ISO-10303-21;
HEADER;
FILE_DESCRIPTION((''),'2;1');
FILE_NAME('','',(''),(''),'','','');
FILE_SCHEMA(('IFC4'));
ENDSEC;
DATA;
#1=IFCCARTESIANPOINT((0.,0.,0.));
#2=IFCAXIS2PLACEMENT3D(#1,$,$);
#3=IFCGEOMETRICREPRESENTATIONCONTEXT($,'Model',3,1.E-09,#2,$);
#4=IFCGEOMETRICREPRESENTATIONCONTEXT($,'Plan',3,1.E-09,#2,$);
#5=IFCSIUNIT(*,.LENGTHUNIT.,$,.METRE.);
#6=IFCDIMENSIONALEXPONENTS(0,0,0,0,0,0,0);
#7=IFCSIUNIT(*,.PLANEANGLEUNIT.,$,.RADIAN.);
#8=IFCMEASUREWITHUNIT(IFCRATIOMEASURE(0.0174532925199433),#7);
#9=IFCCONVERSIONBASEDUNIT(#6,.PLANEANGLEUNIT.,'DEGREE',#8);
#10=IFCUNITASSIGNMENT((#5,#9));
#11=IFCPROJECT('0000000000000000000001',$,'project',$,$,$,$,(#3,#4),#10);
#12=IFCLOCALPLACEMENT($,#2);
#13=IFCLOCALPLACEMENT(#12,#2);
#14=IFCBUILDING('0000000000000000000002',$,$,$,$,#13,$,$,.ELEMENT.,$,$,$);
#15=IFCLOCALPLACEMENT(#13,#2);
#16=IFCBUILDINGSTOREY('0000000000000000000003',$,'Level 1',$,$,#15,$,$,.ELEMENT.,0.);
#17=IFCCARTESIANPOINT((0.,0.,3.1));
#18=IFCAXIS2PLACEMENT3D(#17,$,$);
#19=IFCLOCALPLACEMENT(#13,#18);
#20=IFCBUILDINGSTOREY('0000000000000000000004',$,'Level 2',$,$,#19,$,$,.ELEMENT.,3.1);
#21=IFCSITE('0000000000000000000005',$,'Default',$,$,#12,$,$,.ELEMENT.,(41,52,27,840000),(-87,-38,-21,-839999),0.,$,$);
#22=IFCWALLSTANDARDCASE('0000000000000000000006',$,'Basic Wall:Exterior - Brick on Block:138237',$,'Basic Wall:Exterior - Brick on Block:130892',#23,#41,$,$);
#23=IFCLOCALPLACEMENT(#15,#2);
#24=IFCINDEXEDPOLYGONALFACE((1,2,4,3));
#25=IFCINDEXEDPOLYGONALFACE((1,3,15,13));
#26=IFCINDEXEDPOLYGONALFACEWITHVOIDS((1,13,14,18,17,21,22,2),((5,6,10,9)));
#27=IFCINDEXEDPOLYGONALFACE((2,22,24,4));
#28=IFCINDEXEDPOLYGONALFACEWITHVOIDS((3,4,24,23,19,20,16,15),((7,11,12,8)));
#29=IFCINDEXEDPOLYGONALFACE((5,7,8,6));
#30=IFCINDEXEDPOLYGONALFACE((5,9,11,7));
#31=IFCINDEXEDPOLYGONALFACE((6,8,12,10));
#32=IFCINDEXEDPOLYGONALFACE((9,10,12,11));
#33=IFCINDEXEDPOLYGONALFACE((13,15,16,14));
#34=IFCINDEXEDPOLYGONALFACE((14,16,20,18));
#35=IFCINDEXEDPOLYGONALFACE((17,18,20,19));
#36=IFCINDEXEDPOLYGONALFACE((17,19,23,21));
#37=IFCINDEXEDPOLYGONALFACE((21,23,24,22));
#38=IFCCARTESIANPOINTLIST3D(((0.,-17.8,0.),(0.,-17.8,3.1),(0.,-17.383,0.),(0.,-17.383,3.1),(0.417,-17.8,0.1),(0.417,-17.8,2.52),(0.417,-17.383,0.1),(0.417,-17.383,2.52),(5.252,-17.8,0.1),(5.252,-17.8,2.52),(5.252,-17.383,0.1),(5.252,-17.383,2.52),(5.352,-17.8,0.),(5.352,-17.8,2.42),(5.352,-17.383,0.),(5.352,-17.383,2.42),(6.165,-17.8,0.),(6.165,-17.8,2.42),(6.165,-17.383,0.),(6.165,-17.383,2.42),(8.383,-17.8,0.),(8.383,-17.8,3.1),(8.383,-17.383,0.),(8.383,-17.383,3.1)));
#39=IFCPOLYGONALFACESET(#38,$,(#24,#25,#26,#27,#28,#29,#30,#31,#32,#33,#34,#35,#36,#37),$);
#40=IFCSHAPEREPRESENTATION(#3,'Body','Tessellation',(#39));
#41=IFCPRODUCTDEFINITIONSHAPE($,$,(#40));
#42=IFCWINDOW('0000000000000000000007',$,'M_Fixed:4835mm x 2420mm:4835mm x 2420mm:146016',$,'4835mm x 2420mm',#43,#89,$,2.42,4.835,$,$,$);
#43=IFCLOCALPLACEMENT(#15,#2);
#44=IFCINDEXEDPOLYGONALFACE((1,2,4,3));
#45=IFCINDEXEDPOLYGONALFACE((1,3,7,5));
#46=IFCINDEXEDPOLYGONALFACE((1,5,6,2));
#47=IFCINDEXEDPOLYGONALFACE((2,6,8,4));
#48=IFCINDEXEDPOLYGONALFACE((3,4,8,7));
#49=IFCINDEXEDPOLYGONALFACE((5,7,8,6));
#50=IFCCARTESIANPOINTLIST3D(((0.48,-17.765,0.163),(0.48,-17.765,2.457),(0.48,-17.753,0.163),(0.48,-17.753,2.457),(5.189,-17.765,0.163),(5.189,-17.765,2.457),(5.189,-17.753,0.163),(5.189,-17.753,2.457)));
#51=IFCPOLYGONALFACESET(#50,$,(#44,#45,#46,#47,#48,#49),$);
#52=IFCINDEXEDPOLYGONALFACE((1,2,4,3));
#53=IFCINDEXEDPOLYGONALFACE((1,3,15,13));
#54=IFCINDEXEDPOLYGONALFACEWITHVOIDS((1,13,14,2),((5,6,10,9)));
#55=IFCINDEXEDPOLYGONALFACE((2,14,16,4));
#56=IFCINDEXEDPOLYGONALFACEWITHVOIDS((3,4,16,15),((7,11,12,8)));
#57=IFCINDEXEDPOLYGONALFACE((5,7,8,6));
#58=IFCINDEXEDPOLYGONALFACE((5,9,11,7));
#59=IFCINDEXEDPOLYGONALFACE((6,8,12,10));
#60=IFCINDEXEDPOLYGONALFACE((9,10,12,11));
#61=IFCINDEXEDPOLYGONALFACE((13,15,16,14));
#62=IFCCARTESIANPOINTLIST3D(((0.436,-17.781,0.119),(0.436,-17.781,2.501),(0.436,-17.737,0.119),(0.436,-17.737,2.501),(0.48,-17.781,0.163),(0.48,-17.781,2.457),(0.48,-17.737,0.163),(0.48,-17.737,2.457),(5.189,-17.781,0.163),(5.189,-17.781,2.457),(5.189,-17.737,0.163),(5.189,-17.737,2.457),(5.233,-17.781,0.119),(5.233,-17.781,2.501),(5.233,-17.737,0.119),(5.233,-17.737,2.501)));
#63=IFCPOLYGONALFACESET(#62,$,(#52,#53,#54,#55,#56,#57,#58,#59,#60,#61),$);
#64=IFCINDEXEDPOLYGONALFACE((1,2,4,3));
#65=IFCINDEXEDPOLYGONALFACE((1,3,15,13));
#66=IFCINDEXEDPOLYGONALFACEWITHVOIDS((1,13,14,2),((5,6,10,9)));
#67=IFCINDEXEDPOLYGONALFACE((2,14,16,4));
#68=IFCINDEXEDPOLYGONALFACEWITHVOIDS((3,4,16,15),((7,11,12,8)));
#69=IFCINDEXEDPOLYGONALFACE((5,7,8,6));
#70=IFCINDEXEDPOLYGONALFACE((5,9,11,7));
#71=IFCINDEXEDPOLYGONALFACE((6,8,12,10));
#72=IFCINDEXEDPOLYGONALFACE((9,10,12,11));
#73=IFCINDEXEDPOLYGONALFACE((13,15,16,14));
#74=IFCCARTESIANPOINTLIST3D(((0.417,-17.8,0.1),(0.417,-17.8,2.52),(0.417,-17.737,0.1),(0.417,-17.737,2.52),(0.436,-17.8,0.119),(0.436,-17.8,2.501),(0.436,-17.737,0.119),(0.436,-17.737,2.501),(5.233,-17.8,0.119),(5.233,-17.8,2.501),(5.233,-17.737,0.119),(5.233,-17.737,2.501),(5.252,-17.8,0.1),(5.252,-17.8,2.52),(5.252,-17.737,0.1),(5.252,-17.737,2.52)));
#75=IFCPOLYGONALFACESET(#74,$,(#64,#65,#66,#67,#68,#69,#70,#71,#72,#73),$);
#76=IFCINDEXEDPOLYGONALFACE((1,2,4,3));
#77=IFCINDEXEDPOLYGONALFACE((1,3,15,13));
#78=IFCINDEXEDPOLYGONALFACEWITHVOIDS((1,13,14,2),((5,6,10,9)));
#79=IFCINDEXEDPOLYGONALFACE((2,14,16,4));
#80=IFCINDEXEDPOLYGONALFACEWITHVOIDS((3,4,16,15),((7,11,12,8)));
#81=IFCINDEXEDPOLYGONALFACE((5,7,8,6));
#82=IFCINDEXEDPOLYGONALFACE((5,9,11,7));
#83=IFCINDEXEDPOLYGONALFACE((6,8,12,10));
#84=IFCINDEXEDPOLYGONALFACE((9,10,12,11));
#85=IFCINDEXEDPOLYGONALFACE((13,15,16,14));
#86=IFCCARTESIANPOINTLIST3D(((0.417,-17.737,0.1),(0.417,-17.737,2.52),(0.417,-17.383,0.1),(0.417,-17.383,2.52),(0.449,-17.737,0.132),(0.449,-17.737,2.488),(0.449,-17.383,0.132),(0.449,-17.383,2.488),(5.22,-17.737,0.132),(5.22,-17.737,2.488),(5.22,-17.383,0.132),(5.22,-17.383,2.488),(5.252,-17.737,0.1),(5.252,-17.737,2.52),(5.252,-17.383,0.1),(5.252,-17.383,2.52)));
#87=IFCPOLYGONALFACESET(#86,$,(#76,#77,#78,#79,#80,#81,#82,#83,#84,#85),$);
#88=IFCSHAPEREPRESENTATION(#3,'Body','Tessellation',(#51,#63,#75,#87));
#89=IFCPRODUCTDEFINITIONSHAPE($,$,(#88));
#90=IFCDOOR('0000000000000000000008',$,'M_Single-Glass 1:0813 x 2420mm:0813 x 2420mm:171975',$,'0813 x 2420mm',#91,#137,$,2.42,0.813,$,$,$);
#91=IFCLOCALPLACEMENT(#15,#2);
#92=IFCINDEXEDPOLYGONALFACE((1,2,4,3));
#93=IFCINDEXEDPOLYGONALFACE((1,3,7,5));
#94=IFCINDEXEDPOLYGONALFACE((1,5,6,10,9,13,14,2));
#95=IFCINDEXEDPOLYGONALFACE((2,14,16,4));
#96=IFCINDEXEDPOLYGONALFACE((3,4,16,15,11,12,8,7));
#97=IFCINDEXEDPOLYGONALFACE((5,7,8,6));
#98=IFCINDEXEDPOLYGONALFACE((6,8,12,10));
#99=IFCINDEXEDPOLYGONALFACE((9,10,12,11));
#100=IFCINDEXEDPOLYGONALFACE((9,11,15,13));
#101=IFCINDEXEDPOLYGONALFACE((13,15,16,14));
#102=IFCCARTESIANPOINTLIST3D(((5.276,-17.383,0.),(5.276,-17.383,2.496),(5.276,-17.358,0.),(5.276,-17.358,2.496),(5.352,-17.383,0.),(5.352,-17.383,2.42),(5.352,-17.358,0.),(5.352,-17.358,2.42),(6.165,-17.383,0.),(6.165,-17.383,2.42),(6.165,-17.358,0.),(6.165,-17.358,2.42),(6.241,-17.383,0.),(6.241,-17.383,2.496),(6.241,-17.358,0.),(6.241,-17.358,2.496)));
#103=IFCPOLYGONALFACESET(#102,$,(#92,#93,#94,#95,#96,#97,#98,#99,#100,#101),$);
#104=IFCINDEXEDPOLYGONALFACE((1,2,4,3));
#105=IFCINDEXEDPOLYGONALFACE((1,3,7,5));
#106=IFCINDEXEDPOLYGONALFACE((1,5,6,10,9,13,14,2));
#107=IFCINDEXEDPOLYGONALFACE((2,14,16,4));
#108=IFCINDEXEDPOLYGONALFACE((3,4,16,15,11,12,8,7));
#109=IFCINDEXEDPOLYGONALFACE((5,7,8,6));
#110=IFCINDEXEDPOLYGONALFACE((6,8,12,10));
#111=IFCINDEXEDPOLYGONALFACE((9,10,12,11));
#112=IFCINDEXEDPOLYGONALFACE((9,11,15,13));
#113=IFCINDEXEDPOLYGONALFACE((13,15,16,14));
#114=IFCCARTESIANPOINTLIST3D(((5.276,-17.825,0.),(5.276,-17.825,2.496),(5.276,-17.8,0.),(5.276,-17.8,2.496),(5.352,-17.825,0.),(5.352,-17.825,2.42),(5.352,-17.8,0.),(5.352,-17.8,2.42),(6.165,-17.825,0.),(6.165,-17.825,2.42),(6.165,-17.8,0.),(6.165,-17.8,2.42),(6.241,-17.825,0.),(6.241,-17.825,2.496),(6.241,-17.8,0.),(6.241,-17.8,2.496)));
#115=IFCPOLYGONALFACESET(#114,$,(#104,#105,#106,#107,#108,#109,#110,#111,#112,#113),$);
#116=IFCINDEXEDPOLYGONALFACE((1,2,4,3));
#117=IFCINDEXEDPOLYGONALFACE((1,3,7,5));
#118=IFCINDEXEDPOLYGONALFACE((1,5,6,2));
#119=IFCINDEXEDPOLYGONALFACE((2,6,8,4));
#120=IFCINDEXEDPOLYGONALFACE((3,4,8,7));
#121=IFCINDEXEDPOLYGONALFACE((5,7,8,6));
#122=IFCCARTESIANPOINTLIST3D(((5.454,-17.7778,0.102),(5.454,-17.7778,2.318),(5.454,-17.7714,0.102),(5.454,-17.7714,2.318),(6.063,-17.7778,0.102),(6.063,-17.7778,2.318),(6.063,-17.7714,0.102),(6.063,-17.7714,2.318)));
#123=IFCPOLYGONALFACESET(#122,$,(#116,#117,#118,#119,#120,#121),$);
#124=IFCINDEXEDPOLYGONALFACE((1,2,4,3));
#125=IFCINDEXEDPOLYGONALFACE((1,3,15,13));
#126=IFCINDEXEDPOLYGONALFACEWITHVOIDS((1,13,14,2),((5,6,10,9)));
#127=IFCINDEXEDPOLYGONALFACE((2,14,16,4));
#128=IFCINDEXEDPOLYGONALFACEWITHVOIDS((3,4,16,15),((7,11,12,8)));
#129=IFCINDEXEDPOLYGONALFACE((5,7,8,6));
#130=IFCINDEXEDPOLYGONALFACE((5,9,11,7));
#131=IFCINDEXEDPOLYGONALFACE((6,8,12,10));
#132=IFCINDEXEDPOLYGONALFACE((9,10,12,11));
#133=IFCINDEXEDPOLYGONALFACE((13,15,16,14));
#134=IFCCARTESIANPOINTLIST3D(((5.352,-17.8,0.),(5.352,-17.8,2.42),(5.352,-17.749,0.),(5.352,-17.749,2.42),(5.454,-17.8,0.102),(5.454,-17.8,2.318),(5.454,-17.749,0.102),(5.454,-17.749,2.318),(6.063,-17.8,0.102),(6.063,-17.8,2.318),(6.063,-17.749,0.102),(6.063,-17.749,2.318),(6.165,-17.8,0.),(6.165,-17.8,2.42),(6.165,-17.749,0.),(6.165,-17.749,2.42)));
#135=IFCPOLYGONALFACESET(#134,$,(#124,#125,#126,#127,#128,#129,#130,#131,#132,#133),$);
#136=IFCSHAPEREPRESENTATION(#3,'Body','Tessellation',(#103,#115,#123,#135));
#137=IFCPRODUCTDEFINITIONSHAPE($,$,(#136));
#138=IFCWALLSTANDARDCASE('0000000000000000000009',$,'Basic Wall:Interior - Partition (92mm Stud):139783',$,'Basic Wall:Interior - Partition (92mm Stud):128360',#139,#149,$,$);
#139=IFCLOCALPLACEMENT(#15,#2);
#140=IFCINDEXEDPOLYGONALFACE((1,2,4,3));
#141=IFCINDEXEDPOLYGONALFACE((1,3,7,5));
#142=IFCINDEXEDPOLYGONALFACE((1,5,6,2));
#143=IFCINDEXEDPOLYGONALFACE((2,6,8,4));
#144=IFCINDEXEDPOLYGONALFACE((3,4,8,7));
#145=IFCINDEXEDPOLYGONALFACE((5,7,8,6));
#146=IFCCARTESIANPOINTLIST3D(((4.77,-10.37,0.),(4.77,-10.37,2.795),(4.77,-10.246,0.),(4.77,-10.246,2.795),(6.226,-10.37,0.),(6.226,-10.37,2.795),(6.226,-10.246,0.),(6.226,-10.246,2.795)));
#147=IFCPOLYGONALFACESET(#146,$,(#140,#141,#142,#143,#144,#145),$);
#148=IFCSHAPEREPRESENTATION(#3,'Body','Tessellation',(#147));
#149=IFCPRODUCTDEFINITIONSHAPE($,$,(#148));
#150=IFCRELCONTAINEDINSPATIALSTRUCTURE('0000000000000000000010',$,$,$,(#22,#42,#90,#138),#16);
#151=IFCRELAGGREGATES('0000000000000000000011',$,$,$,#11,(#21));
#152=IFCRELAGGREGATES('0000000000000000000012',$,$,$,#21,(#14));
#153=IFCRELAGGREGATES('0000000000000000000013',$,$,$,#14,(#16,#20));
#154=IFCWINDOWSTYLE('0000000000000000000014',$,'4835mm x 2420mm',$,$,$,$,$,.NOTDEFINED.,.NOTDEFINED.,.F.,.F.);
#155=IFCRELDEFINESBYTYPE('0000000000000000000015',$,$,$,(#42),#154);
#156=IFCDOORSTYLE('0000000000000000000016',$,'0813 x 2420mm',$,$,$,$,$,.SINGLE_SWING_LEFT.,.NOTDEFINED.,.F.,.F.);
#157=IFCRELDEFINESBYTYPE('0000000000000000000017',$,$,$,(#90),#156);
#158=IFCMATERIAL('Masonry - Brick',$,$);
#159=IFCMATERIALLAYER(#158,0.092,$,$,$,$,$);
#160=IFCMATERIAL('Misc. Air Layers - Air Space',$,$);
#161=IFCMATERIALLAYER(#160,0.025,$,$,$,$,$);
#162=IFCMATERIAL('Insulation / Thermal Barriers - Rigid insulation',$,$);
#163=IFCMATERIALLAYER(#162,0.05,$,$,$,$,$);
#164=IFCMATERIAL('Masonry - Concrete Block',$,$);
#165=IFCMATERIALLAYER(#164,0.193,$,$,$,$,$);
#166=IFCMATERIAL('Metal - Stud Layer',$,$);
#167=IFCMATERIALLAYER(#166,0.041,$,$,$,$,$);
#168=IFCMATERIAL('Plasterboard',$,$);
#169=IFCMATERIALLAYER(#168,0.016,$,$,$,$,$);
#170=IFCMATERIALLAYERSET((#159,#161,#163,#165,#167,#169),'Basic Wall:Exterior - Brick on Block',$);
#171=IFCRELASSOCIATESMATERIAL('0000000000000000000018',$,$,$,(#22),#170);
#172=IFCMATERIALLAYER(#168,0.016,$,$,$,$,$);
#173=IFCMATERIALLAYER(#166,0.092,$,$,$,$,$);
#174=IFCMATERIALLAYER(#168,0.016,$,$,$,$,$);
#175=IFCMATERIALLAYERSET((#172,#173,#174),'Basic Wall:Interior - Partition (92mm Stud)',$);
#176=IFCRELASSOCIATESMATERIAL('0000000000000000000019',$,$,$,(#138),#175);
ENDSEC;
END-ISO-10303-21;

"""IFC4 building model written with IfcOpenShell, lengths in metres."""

from ifc_helpers import new_model, entity, si_unit, converted_unit, frame, frame_2d, origin, origin_2d_with_axis, place, context, project, spatial, polyline, rectangle, outline, extrude, source, transform, mapped, material, layer, layer_set, layer_usage, type_object, type_shapes, element, fill, save


model = new_model("IFC4")

# Units and contexts
model_context = context("Model", 3, precision=1e-09, world=origin())
plan_context = context("Plan", 3, precision=1e-09, world=origin())
ifc_project = project(units=[si_unit("LENGTHUNIT", "METRE"), converted_unit("PLANEANGLEUNIT", "DEGREE", entity("IfcRatioMeasure", 0.0174532925199433), si_unit("PLANEANGLEUNIT", "RADIAN"), dimensions=[0, 0, 0, 0, 0, 0, 0])], contexts=[model_context, plan_context])

# Site, building, storey
site_placement = place(None, origin())
site = spatial("IfcSite", under=ifc_project, at=site_placement, Name="Default", CompositionType="ELEMENT", RefLatitude=(41, 52, 27, 840000), RefLongitude=(-87, -38, -21, -839999), RefElevation=0.0)
building_placement = place(site_placement, origin())
building = spatial("IfcBuilding", under=site, at=building_placement, CompositionType="ELEMENT")
storey_1_placement = place(building_placement, origin())
storey_1 = spatial("IfcBuildingStorey", under=building, at=storey_1_placement, Name="Level 1", CompositionType="ELEMENT", Elevation=0.0)

# Shared definitions
ifc_material_1 = material(Name="Metal - Stud Layer")
ifc_material_2 = material(Name="Plasterboard")
ifc_material_3 = material(Name="Masonry - Concrete Block")
ifc_material_4 = material(Name="Misc. Air Layers - Air Space")

# Wall, openings, window, door
ifc_material_5 = material(Name="Masonry - Brick")
ifc_layer_1 = layer(ifc_material_5, 0.092)
ifc_layer_2 = layer(ifc_material_4, 0.025)
ifc_material_6 = material(Name="Insulation / Thermal Barriers - Rigid insulation")
ifc_layer_3 = layer(ifc_material_6, 0.05)
ifc_layer_4 = layer(ifc_material_3, 0.193)
ifc_layer_5 = layer(ifc_material_1, 0.041)
ifc_layer_6 = layer(ifc_material_2, 0.016)
ifc_layer_set_1 = layer_set([ifc_layer_1, ifc_layer_2, ifc_layer_3, ifc_layer_4, ifc_layer_5, ifc_layer_6], Name="Basic Wall:Exterior - Brick on Block")
ifc_layer_usage_1 = layer_usage(ifc_layer_set_1, "AXIS2", "NEGATIVE", 0.2085)
wall_1_placement = place(storey_1_placement, frame((8.383, -17.5915, 0.0), z_axis=(0.0, 0.0, 1.0), x_axis=(-1.0, 0.0, 0.0)))
wall_1 = element("IfcWallStandardCase", 1, at=wall_1_placement, inside=storey_1, material=ifc_layer_usage_1, Name="Basic Wall:Exterior - Brick on Block:138237", ObjectType="Basic Wall:Exterior - Brick on Block:130892", context=model_context, shape_type="SweptSolid", body=[
    extrude(rectangle(XDim=8.383, YDim=0.417, at=frame_2d((4.1915, 0.0), x_axis=(-1.0, 0.0))), origin(), (0.0, 0.0, 1.0), 3.1),
])
opening_1_placement = place(wall_1_placement, frame((2.218, -0.2085, 0.0)))
opening_1 = element("IfcOpeningElement", 2, at=opening_1_placement, cuts=wall_1, ObjectType="Opening", context=model_context, shape_type="SweptSolid", body=[
    extrude(rectangle(XDim=0.813, YDim=2.42, at=frame_2d((1.21, 0.4065), x_axis=(0.0, -1.0))), frame((0.0, 0.0, 0.0), z_axis=(0.0, 1.0, 0.0), x_axis=(0.0, 0.0, 1.0)), (0.0, 0.0, 1.0), 0.417),
])
opening_2_placement = place(wall_1_placement, frame((3.131, -0.2085, 0.1)))
opening_2 = element("IfcOpeningElement", 3, at=opening_2_placement, cuts=wall_1, ObjectType="Opening", context=model_context, shape_type="SweptSolid", body=[
    extrude(rectangle(XDim=2.42, YDim=4.835, at=frame_2d((1.21, 2.4175), x_axis=(1.0, 0.0))), frame((0.0, 0.0, 0.0), z_axis=(0.0, 1.0, 0.0), x_axis=(0.0, 0.0, 1.0)), (0.0, 0.0, 1.0), 0.417),
])
window_style_1 = type_object("IfcWindowStyle", Name="4835mm x 2420mm", ConstructionType="NOTDEFINED", OperationType="NOTDEFINED", ParameterTakesPrecedence=False, Sizeable=False)
shared_shape_1 = source(origin(), model_context, "Body", "SweptSolid", [
    extrude(rectangle(XDim=0.012, YDim=4.709, at=origin_2d_with_axis()), frame((2.4175, 0.376, 0.063), z_axis=(0.0, 0.0, 1.0), x_axis=(0.0, -1.0, 0.0)), (0.0, 0.0, 1.0), 2.294),
    extrude(outline(polyline([(-2.3985, -1.191), (2.3985, -1.191), (2.3985, 1.191), (-2.3985, 1.191), (-2.3985, -1.191)]), holes=[polyline([(-2.3545, -1.147), (-2.3545, 1.147), (2.3545, 1.147), (2.3545, -1.147), (-2.3545, -1.147)])]), frame((2.4175, 0.354, 1.21), z_axis=(0.0, 1.0, 0.0), x_axis=(1.0, 0.0, 0.0)), (0.0, 0.0, 1.0), 0.044),
    extrude(outline(polyline([(-2.4175, -1.21), (2.4175, -1.21), (2.4175, 1.21), (-2.4175, 1.21), (-2.4175, -1.21)]), holes=[polyline([(-2.3985, -1.191), (-2.3985, 1.191), (2.3985, 1.191), (2.3985, -1.191), (-2.3985, -1.191)])]), frame((2.4175, 0.354, 1.21), z_axis=(0.0, 1.0, 0.0), x_axis=(1.0, 0.0, 0.0)), (0.0, 0.0, 1.0), 0.063),
    extrude(outline(polyline([(-2.4175, -1.21), (2.4175, -1.21), (2.4175, 1.21), (-2.4175, 1.21), (-2.4175, -1.21)]), holes=[polyline([(-2.3855, -1.178), (-2.3855, 1.178), (2.3855, 1.178), (2.3855, -1.178), (-2.3855, -1.178)])]), frame((2.4175, 0.0, 1.21), z_axis=(0.0, 1.0, 0.0), x_axis=(1.0, 0.0, 0.0)), (0.0, 0.0, 1.0), 0.354),
])
type_shapes(window_style_1, [shared_shape_1])
window_1_placement = place(opening_2_placement, origin())
window_1 = element("IfcWindow", 4, at=window_1_placement, inside=storey_1, type_object=window_style_1, Name="M_Fixed:4835mm x 2420mm:4835mm x 2420mm:146016", ObjectType="4835mm x 2420mm", OverallHeight=2.42, OverallWidth=4.835, context=model_context, shape_type="MappedRepresentation", body=[
    mapped(shared_shape_1, transform((0.0, 0.0, 0.0), scale=1.0)),
])
fill(opening_2, window_1)
door_style_1 = type_object("IfcDoorStyle", Name="0813 x 2420mm", ConstructionType="NOTDEFINED", OperationType="SINGLE_SWING_LEFT", ParameterTakesPrecedence=False, Sizeable=False)
shared_shape_2 = source(origin(), model_context, "Body", "SweptSolid", [
    extrude(outline(polyline([(-0.4065, -1.191), (-0.4065, 1.229), (-0.4825, 1.229), (-0.4825, -1.267), (0.4825, -1.267), (0.4825, 1.229), (0.4065, 1.229), (0.4065, -1.191), (-0.4065, -1.191)])), frame((0.4065, 0.0, 1.229), z_axis=(0.0, 1.0, 0.0), x_axis=(1.0, 0.0, 0.0)), (0.0, 0.0, -1.0), 0.025),
    extrude(outline(polyline([(-0.4065, -1.191), (-0.4065, 1.229), (-0.4825, 1.229), (-0.4825, -1.267), (0.4825, -1.267), (0.4825, 1.229), (0.4065, 1.229), (0.4065, -1.191), (-0.4065, -1.191)])), frame((0.4065, 0.442, 1.229), z_axis=(0.0, 1.0, 0.0), x_axis=(1.0, 0.0, 0.0)), (0.0, 0.0, -1.0), 0.025),
    extrude(rectangle(XDim=0.609, YDim=0.0064, at=origin_2d_with_axis()), frame((0.4065, 0.3916, 0.102)), (0.0, 0.0, 1.0), 2.216),
    extrude(outline(polyline([(-1.21, -0.4065), (1.21, -0.4065), (1.21, 0.4065), (-1.21, 0.4065), (-1.21, -0.4065)]), holes=[polyline([(-1.108, 0.3045), (1.108, 0.3045), (1.108, -0.3045), (-1.108, -0.3045), (-1.108, 0.3045)])]), frame((0.4065, 0.417, 1.21), z_axis=(0.0, -1.0, 0.0), x_axis=(0.0, 0.0, -1.0)), (0.0, 0.0, 1.0), 0.051),
])
type_shapes(door_style_1, [shared_shape_2])
door_1_placement = place(opening_1_placement, origin())
door_1 = element("IfcDoor", 5, at=door_1_placement, inside=storey_1, type_object=door_style_1, Name="M_Single-Glass 1:0813 x 2420mm:0813 x 2420mm:171975", ObjectType="0813 x 2420mm", OverallHeight=2.42, OverallWidth=0.813, context=model_context, shape_type="MappedRepresentation", body=[
    mapped(shared_shape_2, transform((0.0, 0.0, 0.0), scale=1.0)),
])
fill(opening_1, door_1)

# Wall
ifc_layer_7 = layer(ifc_material_2, 0.016)
ifc_layer_8 = layer(ifc_material_1, 0.092)
ifc_layer_9 = layer(ifc_material_2, 0.016)
ifc_layer_set_2 = layer_set([ifc_layer_7, ifc_layer_8, ifc_layer_9], Name="Basic Wall:Interior - Partition (92mm Stud)")
ifc_layer_usage_2 = layer_usage(ifc_layer_set_2, "AXIS2", "NEGATIVE", 0.062)
wall_2_placement = place(storey_1_placement, frame((4.77, -10.308, 0.0)))
element("IfcWallStandardCase", 6, at=wall_2_placement, inside=storey_1, material=ifc_layer_usage_2, Name="Basic Wall:Interior - Partition (92mm Stud):139783", ObjectType="Basic Wall:Interior - Partition (92mm Stud):128360", context=model_context, shape_type="SweptSolid", body=[
    extrude(rectangle(XDim=1.456, YDim=0.124, at=frame_2d((0.728, 0.0), x_axis=(-1.0, 0.0))), origin(), (0.0, 0.0, 1.0), 2.795),
])

# Shared definitions
storey_2_placement = place(building_placement, frame((0.0, 0.0, 3.1)))
storey_2 = spatial("IfcBuildingStorey", under=building, at=storey_2_placement, Name="Level 2", CompositionType="ELEMENT", Elevation=3.1)

save(model, "model.ifc")
